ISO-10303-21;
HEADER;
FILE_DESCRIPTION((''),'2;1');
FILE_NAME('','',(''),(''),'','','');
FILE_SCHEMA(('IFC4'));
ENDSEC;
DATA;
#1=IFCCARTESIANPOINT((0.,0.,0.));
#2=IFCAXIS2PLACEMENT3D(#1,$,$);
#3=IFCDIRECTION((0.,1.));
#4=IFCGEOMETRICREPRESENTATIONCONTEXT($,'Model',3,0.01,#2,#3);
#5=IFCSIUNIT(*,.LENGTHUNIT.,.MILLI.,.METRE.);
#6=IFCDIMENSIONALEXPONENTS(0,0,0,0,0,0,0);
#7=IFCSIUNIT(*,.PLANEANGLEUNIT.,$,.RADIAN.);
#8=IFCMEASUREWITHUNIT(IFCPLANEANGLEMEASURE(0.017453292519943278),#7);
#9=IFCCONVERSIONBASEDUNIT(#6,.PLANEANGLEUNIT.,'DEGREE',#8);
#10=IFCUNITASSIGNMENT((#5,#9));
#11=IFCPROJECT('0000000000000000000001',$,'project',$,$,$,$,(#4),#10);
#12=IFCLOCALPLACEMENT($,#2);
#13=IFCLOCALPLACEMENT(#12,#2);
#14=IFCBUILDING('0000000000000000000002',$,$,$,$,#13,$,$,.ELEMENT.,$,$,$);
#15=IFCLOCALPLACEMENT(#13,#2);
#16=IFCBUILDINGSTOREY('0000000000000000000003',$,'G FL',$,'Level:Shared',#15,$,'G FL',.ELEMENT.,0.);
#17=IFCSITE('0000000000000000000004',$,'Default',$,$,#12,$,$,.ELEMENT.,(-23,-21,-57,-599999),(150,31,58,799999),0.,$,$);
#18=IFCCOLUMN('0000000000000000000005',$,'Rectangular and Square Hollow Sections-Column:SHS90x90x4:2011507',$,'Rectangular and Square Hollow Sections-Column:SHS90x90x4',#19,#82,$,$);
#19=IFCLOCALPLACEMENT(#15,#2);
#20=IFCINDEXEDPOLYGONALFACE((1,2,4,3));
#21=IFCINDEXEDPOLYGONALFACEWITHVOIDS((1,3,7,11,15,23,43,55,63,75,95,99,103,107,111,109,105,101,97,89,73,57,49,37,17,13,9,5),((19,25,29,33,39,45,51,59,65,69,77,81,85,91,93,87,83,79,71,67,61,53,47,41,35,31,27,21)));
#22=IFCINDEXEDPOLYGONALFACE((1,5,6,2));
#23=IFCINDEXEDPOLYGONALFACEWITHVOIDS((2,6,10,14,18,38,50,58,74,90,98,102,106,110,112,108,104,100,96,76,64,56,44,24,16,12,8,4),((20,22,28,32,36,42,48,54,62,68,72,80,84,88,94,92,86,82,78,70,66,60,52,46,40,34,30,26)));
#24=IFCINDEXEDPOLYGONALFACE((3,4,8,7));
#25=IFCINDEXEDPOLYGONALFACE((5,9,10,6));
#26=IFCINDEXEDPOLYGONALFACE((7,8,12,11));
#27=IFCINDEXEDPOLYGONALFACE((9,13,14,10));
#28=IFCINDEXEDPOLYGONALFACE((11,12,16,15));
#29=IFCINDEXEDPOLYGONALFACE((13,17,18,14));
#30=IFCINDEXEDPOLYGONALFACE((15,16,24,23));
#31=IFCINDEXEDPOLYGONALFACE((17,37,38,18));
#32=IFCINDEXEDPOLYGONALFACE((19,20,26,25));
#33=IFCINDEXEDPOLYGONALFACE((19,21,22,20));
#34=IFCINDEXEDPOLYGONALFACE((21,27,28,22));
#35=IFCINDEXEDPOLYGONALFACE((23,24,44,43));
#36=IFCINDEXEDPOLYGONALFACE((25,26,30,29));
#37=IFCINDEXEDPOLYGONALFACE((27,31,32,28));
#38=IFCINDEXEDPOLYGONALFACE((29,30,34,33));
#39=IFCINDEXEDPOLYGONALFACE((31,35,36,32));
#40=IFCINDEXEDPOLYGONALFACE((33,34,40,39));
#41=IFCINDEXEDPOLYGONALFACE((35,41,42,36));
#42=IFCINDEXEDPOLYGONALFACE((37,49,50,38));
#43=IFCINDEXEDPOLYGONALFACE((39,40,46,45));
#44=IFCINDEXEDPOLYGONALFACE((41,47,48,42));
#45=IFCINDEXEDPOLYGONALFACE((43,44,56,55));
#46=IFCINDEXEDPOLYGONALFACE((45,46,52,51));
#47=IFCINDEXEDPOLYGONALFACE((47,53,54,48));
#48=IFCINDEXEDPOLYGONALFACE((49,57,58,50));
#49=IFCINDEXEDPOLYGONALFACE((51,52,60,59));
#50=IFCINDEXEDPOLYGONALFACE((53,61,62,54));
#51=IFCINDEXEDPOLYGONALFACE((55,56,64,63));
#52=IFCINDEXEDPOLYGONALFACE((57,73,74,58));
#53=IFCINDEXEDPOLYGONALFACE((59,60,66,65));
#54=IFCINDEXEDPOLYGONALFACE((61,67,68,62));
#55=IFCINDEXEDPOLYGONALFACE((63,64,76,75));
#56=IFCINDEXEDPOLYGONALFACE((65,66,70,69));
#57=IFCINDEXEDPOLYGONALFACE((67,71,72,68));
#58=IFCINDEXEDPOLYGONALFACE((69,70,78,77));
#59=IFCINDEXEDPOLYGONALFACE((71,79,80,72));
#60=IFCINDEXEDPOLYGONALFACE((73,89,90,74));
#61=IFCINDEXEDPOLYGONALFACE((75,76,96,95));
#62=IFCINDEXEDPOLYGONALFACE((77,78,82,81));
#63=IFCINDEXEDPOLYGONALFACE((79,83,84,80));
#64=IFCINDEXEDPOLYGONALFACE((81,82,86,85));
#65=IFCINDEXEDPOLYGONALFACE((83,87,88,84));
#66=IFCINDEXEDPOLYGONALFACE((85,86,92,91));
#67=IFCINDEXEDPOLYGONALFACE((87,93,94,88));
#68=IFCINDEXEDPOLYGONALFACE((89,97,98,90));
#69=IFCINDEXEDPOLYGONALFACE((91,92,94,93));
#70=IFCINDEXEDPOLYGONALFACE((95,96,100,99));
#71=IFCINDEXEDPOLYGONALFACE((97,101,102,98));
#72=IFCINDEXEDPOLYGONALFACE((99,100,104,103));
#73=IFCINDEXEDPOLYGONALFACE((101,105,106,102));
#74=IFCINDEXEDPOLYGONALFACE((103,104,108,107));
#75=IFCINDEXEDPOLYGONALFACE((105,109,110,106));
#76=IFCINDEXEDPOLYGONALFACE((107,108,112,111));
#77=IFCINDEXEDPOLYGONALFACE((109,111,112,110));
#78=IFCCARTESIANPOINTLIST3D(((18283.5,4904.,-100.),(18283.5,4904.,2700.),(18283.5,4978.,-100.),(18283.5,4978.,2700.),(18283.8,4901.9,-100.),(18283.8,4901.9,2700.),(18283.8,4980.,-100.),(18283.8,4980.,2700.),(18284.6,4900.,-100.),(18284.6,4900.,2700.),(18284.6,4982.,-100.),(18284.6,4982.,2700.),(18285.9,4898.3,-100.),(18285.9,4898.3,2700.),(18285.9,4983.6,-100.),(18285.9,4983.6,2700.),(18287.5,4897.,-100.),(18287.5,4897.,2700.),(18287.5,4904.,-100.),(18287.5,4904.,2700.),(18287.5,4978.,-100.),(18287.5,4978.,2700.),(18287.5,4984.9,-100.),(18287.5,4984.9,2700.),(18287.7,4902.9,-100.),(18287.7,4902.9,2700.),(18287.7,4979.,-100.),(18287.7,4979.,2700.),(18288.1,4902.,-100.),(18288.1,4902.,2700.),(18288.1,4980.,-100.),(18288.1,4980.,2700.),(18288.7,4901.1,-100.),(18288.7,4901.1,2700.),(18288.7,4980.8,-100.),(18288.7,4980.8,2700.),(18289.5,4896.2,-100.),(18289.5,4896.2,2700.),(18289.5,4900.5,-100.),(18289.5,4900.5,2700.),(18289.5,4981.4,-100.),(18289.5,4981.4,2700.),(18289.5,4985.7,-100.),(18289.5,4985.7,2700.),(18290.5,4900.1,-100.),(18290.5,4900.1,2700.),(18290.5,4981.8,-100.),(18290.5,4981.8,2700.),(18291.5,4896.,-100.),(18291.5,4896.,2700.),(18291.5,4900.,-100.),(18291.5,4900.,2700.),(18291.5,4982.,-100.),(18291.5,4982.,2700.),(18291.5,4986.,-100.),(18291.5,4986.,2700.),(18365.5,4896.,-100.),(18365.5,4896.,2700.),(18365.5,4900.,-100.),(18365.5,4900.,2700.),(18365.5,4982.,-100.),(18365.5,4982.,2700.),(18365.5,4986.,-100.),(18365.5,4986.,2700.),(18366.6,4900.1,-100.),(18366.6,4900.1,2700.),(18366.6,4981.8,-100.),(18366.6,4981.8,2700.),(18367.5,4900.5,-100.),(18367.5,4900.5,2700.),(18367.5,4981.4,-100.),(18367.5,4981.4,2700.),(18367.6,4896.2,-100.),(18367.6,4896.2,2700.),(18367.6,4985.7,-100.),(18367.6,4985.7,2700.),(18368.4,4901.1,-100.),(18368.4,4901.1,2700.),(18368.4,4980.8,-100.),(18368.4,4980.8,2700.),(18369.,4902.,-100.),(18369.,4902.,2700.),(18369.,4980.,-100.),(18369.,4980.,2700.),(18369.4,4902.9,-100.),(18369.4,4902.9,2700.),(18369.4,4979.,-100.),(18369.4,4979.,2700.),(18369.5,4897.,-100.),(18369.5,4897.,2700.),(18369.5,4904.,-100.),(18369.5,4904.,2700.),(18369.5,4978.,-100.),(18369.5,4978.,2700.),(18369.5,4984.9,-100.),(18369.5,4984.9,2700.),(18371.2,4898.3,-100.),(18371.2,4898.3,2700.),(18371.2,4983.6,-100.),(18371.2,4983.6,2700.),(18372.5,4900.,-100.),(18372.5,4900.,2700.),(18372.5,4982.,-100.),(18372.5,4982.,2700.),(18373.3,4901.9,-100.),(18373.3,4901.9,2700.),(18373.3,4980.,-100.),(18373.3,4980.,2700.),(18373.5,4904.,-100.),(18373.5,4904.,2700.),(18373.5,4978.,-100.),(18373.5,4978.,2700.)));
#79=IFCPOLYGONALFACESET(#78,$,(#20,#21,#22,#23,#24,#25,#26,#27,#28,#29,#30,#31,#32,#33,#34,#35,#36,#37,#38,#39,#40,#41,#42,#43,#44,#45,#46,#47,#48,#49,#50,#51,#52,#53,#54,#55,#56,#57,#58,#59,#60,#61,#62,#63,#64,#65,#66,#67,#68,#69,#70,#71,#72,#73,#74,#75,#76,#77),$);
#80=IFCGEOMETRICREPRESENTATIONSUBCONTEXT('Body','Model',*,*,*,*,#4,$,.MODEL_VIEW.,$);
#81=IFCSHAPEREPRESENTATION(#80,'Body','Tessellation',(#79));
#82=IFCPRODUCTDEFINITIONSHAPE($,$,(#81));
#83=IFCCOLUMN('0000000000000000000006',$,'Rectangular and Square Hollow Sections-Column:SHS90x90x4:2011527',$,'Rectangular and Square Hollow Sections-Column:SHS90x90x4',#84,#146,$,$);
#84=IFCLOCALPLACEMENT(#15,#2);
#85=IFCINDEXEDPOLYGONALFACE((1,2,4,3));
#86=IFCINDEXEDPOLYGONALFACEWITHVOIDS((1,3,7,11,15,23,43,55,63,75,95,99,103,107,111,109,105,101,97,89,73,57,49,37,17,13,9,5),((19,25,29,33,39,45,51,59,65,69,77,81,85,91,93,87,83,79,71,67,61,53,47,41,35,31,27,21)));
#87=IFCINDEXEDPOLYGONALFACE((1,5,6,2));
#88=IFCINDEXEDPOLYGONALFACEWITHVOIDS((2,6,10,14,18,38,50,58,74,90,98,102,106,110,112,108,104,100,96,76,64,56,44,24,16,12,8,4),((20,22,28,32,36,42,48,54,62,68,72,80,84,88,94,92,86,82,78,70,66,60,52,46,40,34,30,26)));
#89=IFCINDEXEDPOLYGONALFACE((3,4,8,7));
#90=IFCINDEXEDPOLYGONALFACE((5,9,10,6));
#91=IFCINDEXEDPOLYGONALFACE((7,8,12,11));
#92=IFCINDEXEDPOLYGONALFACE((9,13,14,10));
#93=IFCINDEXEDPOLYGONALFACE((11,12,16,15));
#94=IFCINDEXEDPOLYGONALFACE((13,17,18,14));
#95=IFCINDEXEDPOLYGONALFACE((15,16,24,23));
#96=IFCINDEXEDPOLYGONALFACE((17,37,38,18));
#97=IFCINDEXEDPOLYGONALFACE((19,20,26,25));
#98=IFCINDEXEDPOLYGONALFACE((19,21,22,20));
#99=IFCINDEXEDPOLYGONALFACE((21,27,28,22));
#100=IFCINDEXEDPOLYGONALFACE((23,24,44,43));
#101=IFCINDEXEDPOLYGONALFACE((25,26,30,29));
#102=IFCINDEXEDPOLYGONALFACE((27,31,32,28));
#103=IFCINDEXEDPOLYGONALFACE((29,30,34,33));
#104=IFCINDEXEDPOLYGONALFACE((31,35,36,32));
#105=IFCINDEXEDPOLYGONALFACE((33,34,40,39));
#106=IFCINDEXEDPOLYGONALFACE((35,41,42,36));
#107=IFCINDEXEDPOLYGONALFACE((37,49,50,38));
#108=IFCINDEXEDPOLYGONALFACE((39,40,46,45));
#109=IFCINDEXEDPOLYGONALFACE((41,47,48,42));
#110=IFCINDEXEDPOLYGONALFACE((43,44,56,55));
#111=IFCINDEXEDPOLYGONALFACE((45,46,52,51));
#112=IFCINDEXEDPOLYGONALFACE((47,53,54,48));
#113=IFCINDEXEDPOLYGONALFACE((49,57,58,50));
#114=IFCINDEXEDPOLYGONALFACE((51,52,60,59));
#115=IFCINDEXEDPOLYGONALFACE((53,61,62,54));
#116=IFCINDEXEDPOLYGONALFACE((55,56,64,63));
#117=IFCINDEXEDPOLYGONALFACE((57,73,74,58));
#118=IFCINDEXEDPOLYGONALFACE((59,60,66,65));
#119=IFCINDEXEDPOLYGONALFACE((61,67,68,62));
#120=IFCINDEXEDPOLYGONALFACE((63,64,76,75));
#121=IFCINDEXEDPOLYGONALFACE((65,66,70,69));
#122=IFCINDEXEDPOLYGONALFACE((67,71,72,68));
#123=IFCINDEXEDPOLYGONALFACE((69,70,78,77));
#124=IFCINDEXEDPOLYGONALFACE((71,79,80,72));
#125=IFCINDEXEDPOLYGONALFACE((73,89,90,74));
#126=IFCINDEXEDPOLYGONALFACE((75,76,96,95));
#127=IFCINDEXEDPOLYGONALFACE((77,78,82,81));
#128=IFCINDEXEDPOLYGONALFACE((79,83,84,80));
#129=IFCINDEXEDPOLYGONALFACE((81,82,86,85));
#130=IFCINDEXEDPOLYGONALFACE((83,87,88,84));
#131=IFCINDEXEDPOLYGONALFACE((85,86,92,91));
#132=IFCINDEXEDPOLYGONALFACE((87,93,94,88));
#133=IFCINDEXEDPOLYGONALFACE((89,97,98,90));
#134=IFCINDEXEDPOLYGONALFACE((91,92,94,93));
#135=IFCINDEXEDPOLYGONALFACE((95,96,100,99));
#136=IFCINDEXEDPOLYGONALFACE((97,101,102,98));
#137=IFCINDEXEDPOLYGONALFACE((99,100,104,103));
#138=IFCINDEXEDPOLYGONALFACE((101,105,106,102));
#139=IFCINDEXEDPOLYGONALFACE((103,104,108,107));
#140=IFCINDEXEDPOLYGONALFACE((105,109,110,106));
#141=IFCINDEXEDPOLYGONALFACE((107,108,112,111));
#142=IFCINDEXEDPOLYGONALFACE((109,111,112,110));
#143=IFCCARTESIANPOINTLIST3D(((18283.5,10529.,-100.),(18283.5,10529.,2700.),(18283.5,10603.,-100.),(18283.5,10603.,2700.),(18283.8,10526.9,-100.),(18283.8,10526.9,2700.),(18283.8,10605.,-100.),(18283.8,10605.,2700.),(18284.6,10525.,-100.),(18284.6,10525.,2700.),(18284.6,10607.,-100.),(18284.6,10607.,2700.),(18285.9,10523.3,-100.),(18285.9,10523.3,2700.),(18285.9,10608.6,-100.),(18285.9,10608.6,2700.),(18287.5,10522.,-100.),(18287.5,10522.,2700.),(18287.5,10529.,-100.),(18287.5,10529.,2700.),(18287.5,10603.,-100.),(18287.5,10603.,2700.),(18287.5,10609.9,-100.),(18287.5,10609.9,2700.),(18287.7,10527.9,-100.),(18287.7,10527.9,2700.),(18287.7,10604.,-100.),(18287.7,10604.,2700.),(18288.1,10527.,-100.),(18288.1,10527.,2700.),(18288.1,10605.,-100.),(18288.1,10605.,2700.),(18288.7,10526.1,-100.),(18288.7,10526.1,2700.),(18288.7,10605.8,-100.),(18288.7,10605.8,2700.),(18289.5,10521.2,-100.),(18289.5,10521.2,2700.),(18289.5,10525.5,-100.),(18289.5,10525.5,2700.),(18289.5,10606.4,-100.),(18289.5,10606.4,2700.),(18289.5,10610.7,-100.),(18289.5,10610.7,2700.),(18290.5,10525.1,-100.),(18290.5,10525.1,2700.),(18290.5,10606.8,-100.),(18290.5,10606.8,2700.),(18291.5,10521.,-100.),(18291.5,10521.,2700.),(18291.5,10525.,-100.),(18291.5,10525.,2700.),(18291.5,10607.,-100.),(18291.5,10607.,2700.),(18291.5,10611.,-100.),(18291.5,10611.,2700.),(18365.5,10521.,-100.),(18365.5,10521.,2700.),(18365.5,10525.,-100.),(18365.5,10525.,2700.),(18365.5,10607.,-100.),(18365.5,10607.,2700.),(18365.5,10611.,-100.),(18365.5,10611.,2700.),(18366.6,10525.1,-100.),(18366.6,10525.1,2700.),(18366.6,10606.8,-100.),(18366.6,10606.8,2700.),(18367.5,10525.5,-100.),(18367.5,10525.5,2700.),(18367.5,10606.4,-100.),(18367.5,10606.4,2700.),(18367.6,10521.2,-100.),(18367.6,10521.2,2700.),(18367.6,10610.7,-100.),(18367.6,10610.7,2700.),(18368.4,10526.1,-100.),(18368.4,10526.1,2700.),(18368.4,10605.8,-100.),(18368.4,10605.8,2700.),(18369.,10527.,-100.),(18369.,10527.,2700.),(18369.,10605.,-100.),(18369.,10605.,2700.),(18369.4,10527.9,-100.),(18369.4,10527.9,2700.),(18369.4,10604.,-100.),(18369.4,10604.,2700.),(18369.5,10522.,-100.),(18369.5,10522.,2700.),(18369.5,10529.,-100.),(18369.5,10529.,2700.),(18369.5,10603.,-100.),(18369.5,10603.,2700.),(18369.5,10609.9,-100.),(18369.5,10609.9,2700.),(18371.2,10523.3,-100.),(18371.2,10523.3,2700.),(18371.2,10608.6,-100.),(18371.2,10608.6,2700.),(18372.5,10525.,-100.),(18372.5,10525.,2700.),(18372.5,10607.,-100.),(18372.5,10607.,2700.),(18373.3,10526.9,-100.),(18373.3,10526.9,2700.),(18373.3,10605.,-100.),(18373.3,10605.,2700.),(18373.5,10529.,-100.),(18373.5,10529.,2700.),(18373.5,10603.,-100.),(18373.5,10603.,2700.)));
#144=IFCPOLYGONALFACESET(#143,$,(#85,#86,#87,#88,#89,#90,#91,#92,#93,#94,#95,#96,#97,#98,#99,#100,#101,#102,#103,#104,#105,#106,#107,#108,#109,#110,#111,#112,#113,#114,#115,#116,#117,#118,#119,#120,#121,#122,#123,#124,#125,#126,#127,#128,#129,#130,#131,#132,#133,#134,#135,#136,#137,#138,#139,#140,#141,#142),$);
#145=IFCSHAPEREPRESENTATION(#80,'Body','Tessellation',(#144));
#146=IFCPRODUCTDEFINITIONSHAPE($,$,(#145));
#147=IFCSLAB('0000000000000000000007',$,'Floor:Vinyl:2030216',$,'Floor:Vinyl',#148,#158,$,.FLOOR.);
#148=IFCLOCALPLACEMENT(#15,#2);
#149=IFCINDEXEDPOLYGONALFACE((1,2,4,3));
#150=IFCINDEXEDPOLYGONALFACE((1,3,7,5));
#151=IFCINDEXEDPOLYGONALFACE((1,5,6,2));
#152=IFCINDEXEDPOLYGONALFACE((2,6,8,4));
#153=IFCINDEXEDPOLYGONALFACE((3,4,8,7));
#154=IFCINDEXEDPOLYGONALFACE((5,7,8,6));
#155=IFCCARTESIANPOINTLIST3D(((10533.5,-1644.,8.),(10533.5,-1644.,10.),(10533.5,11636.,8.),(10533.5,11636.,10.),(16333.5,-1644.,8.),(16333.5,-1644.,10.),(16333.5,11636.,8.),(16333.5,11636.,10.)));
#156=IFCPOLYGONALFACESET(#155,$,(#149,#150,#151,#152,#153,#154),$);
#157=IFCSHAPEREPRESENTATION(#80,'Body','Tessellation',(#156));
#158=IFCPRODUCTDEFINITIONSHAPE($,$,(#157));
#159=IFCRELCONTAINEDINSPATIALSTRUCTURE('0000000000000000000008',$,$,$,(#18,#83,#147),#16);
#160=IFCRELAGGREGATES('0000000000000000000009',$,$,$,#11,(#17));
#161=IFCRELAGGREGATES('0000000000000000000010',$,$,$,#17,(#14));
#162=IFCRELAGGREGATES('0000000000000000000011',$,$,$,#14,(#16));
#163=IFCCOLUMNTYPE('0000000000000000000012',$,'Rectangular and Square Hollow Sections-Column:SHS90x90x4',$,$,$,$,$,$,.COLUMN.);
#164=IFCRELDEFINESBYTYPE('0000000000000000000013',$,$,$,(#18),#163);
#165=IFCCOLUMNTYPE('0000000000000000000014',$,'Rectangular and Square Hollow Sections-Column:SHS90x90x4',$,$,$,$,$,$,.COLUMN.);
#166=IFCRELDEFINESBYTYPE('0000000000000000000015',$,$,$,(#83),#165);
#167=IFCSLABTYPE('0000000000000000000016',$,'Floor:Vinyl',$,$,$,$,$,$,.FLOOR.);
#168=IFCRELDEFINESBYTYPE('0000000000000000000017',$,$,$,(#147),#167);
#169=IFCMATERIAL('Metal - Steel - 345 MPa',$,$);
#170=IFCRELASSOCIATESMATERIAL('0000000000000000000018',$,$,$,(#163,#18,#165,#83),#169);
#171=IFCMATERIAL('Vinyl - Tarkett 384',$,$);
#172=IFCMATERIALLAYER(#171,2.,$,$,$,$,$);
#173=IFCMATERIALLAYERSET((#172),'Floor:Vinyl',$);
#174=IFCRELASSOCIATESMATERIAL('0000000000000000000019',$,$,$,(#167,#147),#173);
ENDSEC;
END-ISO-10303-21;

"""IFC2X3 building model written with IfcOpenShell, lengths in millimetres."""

from ifc_helpers import new_model, entity, si_unit, converted_unit, direction, frame, frame_2d, origin, origin_2d_with_axis, place, context, subcontext, project, spatial, polyline, circle_curve, parameter, trimmed, segment, composite_curve, rectangle, outline, extrude, source, transform, mapped, material, layer, layer_set, layer_usage, type_object, type_shapes, element, save


model = new_model("IFC2X3")

# Units and contexts
model_context = context("Model", 3, precision=0.01, world=origin(), true_north=direction((0.0, 1.0)))
body_context = subcontext(model_context, "Body", "Model", "MODEL_VIEW")
ifc_project = project(units=[si_unit("LENGTHUNIT", "METRE", prefix="MILLI"), converted_unit("PLANEANGLEUNIT", "DEGREE", entity("IfcPlaneAngleMeasure", 0.017453292519943278), si_unit("PLANEANGLEUNIT", "RADIAN"), dimensions=[0, 0, 0, 0, 0, 0, 0])], contexts=[model_context])

# Site, building, storey
site_placement = place(None, origin())
site = spatial("IfcSite", under=ifc_project, at=site_placement, Name="Default", CompositionType="ELEMENT", RefLatitude=(-23, -21, -57, -599999), RefLongitude=(150, 31, 58, 799999), RefElevation=0.0)
building_placement = place(site_placement, origin())
building = spatial("IfcBuilding", under=site, at=building_placement, CompositionType="ELEMENT")
storey_placement = place(building_placement, origin())
storey = spatial("IfcBuildingStorey", under=building, at=storey_placement, Name="G FL", ObjectType="Level:Shared", LongName="G FL", CompositionType="ELEMENT", Elevation=0.0)

# Columns
ifc_material_1 = material(Name="Metal - Steel - 345 MPa")
column_type_1 = type_object("IfcColumnType", Name="Rectangular and Square Hollow Sections-Column:SHS90x90x4", PredefinedType="COLUMN", material=ifc_material_1)
shared_shape_1 = source(origin(), body_context, "Body", "SweptSolid", [
    extrude(outline(composite_curve([segment(polyline([(-37.0, -45.0), (37.0, -45.0)]), True, "CONTINUOUS"), segment(trimmed(circle_curve(frame_2d((37.0, -37.0), x_axis=(-1.0, 0.0)), 8.0), [parameter(90.0)], [parameter(180.0)], True, "PARAMETER"), True, "CONTINUOUS"), segment(polyline([(45.0, -37.0), (45.0, 37.0)]), True, "CONTINUOUS"), segment(trimmed(circle_curve(frame_2d((37.0, 37.0), x_axis=(-1.0, 0.0)), 8.0), [parameter(180.0)], [parameter(270.0)], True, "PARAMETER"), True, "CONTINUOUS"), segment(polyline([(37.0, 45.0), (-37.0, 45.0)]), True, "CONTINUOUS"), segment(trimmed(circle_curve(frame_2d((-37.0, 37.0), x_axis=(-1.0, 0.0)), 8.0), [parameter(270.0)], [parameter(360.0)], True, "PARAMETER"), True, "CONTINUOUS"), segment(polyline([(-45.0, 37.0), (-45.0, -37.0)]), True, "CONTINUOUS"), segment(trimmed(circle_curve(frame_2d((-37.0, -37.0), x_axis=(-1.0, 0.0)), 8.0), [parameter(360.0)], [parameter(90.0)], True, "PARAMETER"), True, "CONTINUOUS")], self_intersect=False), holes=[composite_curve([segment(trimmed(circle_curve(frame_2d((-37.0, -37.0), x_axis=(-1.0, 0.0)), 4.0), [parameter(0.0)], [parameter(90.0)], True, "PARAMETER"), False, "CONTINUOUS"), segment(polyline([(-41.0, -37.0), (-41.0, 37.0)]), True, "CONTINUOUS"), segment(trimmed(circle_curve(frame_2d((-37.0, 37.0), x_axis=(-1.0, 0.0)), 4.0), [parameter(270.0)], [parameter(360.0)], True, "PARAMETER"), False, "CONTINUOUS"), segment(polyline([(-37.0, 41.0), (37.0, 41.0)]), True, "CONTINUOUS"), segment(trimmed(circle_curve(frame_2d((37.0, 37.0), x_axis=(-1.0, 0.0)), 4.0), [parameter(180.0)], [parameter(270.0)], True, "PARAMETER"), False, "CONTINUOUS"), segment(polyline([(41.0, 37.0), (41.0, -37.0)]), True, "CONTINUOUS"), segment(trimmed(circle_curve(frame_2d((37.0, -37.0), x_axis=(-1.0, 0.0)), 4.0), [parameter(90.0)], [parameter(180.0)], True, "PARAMETER"), False, "CONTINUOUS"), segment(polyline([(37.0, -41.0), (-37.0, -41.0)]), True, "CONTINUOUS")], self_intersect=False)]), frame((18328.5, 4941.0, -100.0), z_axis=(0.0, 0.0, 1.0), x_axis=(-1.0, 0.0, 0.0)), (0.0, 0.0, 1.0), 2800.0),
])
type_shapes(column_type_1, [shared_shape_1])
column_1_placement = place(storey_placement, origin())
element("IfcColumn", 1, at=column_1_placement, inside=storey, type_object=column_type_1, material=ifc_material_1, Name="Rectangular and Square Hollow Sections-Column:SHS90x90x4:2011507", ObjectType="Rectangular and Square Hollow Sections-Column:SHS90x90x4", context=body_context, shape_type="MappedRepresentation", body=[
    mapped(shared_shape_1, transform((0.0, 0.0, 0.0), scale=1.0)),
])
column_type_2 = type_object("IfcColumnType", Name="Rectangular and Square Hollow Sections-Column:SHS90x90x4", PredefinedType="COLUMN", material=ifc_material_1)
shared_shape_2 = source(origin(), body_context, "Body", "SweptSolid", [
    extrude(outline(composite_curve([segment(polyline([(-37.0, -45.0), (37.0, -45.0)]), True, "CONTINUOUS"), segment(trimmed(circle_curve(frame_2d((37.0, -37.0), x_axis=(-1.0, 0.0)), 8.0), [parameter(90.0)], [parameter(180.0)], True, "PARAMETER"), True, "CONTINUOUS"), segment(polyline([(45.0, -37.0), (45.0, 37.0)]), True, "CONTINUOUS"), segment(trimmed(circle_curve(frame_2d((37.0, 37.0), x_axis=(-1.0, 0.0)), 8.0), [parameter(180.0)], [parameter(270.0)], True, "PARAMETER"), True, "CONTINUOUS"), segment(polyline([(37.0, 45.0), (-37.0, 45.0)]), True, "CONTINUOUS"), segment(trimmed(circle_curve(frame_2d((-37.0, 37.0), x_axis=(-1.0, 0.0)), 8.0), [parameter(270.0)], [parameter(360.0)], True, "PARAMETER"), True, "CONTINUOUS"), segment(polyline([(-45.0, 37.0), (-45.0, -37.0)]), True, "CONTINUOUS"), segment(trimmed(circle_curve(frame_2d((-37.0, -37.0), x_axis=(-1.0, 0.0)), 8.0), [parameter(360.0)], [parameter(90.0)], True, "PARAMETER"), True, "CONTINUOUS")], self_intersect=False), holes=[composite_curve([segment(trimmed(circle_curve(frame_2d((-37.0, -37.0), x_axis=(-1.0, 0.0)), 4.0), [parameter(0.0)], [parameter(90.0)], True, "PARAMETER"), False, "CONTINUOUS"), segment(polyline([(-41.0, -37.0), (-41.0, 37.0)]), True, "CONTINUOUS"), segment(trimmed(circle_curve(frame_2d((-37.0, 37.0), x_axis=(-1.0, 0.0)), 4.0), [parameter(270.0)], [parameter(360.0)], True, "PARAMETER"), False, "CONTINUOUS"), segment(polyline([(-37.0, 41.0), (37.0, 41.0)]), True, "CONTINUOUS"), segment(trimmed(circle_curve(frame_2d((37.0, 37.0), x_axis=(-1.0, 0.0)), 4.0), [parameter(180.0)], [parameter(270.0)], True, "PARAMETER"), False, "CONTINUOUS"), segment(polyline([(41.0, 37.0), (41.0, -37.0)]), True, "CONTINUOUS"), segment(trimmed(circle_curve(frame_2d((37.0, -37.0), x_axis=(-1.0, 0.0)), 4.0), [parameter(90.0)], [parameter(180.0)], True, "PARAMETER"), False, "CONTINUOUS"), segment(polyline([(37.0, -41.0), (-37.0, -41.0)]), True, "CONTINUOUS")], self_intersect=False)]), frame((18328.5, 10566.0, -100.0), z_axis=(0.0, 0.0, 1.0), x_axis=(-1.0, 0.0, 0.0)), (0.0, 0.0, 1.0), 2800.0),
])
type_shapes(column_type_2, [shared_shape_2])
column_2_placement = place(storey_placement, origin())
element("IfcColumn", 2, at=column_2_placement, inside=storey, type_object=column_type_2, material=ifc_material_1, Name="Rectangular and Square Hollow Sections-Column:SHS90x90x4:2011527", ObjectType="Rectangular and Square Hollow Sections-Column:SHS90x90x4", context=body_context, shape_type="MappedRepresentation", body=[
    mapped(shared_shape_2, transform((0.0, 0.0, 0.0), scale=1.0)),
])

# Slab
ifc_material_2 = material(Name="Vinyl - Tarkett 384")
ifc_layer_1 = layer(ifc_material_2, 2.0)
ifc_layer_set_1 = layer_set([ifc_layer_1], Name="Floor:Vinyl")
ifc_layer_usage_1 = layer_usage(ifc_layer_set_1, "AXIS3", "POSITIVE", 0.0)
slab_type_1 = type_object("IfcSlabType", Name="Floor:Vinyl", PredefinedType="FLOOR", material=ifc_layer_set_1)
slab_1_placement = place(storey_placement, origin())
element("IfcSlab", 3, at=slab_1_placement, inside=storey, type_object=slab_type_1, material=ifc_layer_usage_1, Name="Floor:Vinyl:2030216", ObjectType="Floor:Vinyl", PredefinedType="FLOOR", context=body_context, shape_type="SweptSolid", body=[
    extrude(rectangle(XDim=13280.0, YDim=5800.0, at=origin_2d_with_axis()), frame((13433.5, 4996.0, 10.0), z_axis=(0.0, 0.0, -1.0), x_axis=(0.0, 1.0, 0.0)), (0.0, 0.0, 1.0), 2.0),
])

save(model, "model.ifc")
